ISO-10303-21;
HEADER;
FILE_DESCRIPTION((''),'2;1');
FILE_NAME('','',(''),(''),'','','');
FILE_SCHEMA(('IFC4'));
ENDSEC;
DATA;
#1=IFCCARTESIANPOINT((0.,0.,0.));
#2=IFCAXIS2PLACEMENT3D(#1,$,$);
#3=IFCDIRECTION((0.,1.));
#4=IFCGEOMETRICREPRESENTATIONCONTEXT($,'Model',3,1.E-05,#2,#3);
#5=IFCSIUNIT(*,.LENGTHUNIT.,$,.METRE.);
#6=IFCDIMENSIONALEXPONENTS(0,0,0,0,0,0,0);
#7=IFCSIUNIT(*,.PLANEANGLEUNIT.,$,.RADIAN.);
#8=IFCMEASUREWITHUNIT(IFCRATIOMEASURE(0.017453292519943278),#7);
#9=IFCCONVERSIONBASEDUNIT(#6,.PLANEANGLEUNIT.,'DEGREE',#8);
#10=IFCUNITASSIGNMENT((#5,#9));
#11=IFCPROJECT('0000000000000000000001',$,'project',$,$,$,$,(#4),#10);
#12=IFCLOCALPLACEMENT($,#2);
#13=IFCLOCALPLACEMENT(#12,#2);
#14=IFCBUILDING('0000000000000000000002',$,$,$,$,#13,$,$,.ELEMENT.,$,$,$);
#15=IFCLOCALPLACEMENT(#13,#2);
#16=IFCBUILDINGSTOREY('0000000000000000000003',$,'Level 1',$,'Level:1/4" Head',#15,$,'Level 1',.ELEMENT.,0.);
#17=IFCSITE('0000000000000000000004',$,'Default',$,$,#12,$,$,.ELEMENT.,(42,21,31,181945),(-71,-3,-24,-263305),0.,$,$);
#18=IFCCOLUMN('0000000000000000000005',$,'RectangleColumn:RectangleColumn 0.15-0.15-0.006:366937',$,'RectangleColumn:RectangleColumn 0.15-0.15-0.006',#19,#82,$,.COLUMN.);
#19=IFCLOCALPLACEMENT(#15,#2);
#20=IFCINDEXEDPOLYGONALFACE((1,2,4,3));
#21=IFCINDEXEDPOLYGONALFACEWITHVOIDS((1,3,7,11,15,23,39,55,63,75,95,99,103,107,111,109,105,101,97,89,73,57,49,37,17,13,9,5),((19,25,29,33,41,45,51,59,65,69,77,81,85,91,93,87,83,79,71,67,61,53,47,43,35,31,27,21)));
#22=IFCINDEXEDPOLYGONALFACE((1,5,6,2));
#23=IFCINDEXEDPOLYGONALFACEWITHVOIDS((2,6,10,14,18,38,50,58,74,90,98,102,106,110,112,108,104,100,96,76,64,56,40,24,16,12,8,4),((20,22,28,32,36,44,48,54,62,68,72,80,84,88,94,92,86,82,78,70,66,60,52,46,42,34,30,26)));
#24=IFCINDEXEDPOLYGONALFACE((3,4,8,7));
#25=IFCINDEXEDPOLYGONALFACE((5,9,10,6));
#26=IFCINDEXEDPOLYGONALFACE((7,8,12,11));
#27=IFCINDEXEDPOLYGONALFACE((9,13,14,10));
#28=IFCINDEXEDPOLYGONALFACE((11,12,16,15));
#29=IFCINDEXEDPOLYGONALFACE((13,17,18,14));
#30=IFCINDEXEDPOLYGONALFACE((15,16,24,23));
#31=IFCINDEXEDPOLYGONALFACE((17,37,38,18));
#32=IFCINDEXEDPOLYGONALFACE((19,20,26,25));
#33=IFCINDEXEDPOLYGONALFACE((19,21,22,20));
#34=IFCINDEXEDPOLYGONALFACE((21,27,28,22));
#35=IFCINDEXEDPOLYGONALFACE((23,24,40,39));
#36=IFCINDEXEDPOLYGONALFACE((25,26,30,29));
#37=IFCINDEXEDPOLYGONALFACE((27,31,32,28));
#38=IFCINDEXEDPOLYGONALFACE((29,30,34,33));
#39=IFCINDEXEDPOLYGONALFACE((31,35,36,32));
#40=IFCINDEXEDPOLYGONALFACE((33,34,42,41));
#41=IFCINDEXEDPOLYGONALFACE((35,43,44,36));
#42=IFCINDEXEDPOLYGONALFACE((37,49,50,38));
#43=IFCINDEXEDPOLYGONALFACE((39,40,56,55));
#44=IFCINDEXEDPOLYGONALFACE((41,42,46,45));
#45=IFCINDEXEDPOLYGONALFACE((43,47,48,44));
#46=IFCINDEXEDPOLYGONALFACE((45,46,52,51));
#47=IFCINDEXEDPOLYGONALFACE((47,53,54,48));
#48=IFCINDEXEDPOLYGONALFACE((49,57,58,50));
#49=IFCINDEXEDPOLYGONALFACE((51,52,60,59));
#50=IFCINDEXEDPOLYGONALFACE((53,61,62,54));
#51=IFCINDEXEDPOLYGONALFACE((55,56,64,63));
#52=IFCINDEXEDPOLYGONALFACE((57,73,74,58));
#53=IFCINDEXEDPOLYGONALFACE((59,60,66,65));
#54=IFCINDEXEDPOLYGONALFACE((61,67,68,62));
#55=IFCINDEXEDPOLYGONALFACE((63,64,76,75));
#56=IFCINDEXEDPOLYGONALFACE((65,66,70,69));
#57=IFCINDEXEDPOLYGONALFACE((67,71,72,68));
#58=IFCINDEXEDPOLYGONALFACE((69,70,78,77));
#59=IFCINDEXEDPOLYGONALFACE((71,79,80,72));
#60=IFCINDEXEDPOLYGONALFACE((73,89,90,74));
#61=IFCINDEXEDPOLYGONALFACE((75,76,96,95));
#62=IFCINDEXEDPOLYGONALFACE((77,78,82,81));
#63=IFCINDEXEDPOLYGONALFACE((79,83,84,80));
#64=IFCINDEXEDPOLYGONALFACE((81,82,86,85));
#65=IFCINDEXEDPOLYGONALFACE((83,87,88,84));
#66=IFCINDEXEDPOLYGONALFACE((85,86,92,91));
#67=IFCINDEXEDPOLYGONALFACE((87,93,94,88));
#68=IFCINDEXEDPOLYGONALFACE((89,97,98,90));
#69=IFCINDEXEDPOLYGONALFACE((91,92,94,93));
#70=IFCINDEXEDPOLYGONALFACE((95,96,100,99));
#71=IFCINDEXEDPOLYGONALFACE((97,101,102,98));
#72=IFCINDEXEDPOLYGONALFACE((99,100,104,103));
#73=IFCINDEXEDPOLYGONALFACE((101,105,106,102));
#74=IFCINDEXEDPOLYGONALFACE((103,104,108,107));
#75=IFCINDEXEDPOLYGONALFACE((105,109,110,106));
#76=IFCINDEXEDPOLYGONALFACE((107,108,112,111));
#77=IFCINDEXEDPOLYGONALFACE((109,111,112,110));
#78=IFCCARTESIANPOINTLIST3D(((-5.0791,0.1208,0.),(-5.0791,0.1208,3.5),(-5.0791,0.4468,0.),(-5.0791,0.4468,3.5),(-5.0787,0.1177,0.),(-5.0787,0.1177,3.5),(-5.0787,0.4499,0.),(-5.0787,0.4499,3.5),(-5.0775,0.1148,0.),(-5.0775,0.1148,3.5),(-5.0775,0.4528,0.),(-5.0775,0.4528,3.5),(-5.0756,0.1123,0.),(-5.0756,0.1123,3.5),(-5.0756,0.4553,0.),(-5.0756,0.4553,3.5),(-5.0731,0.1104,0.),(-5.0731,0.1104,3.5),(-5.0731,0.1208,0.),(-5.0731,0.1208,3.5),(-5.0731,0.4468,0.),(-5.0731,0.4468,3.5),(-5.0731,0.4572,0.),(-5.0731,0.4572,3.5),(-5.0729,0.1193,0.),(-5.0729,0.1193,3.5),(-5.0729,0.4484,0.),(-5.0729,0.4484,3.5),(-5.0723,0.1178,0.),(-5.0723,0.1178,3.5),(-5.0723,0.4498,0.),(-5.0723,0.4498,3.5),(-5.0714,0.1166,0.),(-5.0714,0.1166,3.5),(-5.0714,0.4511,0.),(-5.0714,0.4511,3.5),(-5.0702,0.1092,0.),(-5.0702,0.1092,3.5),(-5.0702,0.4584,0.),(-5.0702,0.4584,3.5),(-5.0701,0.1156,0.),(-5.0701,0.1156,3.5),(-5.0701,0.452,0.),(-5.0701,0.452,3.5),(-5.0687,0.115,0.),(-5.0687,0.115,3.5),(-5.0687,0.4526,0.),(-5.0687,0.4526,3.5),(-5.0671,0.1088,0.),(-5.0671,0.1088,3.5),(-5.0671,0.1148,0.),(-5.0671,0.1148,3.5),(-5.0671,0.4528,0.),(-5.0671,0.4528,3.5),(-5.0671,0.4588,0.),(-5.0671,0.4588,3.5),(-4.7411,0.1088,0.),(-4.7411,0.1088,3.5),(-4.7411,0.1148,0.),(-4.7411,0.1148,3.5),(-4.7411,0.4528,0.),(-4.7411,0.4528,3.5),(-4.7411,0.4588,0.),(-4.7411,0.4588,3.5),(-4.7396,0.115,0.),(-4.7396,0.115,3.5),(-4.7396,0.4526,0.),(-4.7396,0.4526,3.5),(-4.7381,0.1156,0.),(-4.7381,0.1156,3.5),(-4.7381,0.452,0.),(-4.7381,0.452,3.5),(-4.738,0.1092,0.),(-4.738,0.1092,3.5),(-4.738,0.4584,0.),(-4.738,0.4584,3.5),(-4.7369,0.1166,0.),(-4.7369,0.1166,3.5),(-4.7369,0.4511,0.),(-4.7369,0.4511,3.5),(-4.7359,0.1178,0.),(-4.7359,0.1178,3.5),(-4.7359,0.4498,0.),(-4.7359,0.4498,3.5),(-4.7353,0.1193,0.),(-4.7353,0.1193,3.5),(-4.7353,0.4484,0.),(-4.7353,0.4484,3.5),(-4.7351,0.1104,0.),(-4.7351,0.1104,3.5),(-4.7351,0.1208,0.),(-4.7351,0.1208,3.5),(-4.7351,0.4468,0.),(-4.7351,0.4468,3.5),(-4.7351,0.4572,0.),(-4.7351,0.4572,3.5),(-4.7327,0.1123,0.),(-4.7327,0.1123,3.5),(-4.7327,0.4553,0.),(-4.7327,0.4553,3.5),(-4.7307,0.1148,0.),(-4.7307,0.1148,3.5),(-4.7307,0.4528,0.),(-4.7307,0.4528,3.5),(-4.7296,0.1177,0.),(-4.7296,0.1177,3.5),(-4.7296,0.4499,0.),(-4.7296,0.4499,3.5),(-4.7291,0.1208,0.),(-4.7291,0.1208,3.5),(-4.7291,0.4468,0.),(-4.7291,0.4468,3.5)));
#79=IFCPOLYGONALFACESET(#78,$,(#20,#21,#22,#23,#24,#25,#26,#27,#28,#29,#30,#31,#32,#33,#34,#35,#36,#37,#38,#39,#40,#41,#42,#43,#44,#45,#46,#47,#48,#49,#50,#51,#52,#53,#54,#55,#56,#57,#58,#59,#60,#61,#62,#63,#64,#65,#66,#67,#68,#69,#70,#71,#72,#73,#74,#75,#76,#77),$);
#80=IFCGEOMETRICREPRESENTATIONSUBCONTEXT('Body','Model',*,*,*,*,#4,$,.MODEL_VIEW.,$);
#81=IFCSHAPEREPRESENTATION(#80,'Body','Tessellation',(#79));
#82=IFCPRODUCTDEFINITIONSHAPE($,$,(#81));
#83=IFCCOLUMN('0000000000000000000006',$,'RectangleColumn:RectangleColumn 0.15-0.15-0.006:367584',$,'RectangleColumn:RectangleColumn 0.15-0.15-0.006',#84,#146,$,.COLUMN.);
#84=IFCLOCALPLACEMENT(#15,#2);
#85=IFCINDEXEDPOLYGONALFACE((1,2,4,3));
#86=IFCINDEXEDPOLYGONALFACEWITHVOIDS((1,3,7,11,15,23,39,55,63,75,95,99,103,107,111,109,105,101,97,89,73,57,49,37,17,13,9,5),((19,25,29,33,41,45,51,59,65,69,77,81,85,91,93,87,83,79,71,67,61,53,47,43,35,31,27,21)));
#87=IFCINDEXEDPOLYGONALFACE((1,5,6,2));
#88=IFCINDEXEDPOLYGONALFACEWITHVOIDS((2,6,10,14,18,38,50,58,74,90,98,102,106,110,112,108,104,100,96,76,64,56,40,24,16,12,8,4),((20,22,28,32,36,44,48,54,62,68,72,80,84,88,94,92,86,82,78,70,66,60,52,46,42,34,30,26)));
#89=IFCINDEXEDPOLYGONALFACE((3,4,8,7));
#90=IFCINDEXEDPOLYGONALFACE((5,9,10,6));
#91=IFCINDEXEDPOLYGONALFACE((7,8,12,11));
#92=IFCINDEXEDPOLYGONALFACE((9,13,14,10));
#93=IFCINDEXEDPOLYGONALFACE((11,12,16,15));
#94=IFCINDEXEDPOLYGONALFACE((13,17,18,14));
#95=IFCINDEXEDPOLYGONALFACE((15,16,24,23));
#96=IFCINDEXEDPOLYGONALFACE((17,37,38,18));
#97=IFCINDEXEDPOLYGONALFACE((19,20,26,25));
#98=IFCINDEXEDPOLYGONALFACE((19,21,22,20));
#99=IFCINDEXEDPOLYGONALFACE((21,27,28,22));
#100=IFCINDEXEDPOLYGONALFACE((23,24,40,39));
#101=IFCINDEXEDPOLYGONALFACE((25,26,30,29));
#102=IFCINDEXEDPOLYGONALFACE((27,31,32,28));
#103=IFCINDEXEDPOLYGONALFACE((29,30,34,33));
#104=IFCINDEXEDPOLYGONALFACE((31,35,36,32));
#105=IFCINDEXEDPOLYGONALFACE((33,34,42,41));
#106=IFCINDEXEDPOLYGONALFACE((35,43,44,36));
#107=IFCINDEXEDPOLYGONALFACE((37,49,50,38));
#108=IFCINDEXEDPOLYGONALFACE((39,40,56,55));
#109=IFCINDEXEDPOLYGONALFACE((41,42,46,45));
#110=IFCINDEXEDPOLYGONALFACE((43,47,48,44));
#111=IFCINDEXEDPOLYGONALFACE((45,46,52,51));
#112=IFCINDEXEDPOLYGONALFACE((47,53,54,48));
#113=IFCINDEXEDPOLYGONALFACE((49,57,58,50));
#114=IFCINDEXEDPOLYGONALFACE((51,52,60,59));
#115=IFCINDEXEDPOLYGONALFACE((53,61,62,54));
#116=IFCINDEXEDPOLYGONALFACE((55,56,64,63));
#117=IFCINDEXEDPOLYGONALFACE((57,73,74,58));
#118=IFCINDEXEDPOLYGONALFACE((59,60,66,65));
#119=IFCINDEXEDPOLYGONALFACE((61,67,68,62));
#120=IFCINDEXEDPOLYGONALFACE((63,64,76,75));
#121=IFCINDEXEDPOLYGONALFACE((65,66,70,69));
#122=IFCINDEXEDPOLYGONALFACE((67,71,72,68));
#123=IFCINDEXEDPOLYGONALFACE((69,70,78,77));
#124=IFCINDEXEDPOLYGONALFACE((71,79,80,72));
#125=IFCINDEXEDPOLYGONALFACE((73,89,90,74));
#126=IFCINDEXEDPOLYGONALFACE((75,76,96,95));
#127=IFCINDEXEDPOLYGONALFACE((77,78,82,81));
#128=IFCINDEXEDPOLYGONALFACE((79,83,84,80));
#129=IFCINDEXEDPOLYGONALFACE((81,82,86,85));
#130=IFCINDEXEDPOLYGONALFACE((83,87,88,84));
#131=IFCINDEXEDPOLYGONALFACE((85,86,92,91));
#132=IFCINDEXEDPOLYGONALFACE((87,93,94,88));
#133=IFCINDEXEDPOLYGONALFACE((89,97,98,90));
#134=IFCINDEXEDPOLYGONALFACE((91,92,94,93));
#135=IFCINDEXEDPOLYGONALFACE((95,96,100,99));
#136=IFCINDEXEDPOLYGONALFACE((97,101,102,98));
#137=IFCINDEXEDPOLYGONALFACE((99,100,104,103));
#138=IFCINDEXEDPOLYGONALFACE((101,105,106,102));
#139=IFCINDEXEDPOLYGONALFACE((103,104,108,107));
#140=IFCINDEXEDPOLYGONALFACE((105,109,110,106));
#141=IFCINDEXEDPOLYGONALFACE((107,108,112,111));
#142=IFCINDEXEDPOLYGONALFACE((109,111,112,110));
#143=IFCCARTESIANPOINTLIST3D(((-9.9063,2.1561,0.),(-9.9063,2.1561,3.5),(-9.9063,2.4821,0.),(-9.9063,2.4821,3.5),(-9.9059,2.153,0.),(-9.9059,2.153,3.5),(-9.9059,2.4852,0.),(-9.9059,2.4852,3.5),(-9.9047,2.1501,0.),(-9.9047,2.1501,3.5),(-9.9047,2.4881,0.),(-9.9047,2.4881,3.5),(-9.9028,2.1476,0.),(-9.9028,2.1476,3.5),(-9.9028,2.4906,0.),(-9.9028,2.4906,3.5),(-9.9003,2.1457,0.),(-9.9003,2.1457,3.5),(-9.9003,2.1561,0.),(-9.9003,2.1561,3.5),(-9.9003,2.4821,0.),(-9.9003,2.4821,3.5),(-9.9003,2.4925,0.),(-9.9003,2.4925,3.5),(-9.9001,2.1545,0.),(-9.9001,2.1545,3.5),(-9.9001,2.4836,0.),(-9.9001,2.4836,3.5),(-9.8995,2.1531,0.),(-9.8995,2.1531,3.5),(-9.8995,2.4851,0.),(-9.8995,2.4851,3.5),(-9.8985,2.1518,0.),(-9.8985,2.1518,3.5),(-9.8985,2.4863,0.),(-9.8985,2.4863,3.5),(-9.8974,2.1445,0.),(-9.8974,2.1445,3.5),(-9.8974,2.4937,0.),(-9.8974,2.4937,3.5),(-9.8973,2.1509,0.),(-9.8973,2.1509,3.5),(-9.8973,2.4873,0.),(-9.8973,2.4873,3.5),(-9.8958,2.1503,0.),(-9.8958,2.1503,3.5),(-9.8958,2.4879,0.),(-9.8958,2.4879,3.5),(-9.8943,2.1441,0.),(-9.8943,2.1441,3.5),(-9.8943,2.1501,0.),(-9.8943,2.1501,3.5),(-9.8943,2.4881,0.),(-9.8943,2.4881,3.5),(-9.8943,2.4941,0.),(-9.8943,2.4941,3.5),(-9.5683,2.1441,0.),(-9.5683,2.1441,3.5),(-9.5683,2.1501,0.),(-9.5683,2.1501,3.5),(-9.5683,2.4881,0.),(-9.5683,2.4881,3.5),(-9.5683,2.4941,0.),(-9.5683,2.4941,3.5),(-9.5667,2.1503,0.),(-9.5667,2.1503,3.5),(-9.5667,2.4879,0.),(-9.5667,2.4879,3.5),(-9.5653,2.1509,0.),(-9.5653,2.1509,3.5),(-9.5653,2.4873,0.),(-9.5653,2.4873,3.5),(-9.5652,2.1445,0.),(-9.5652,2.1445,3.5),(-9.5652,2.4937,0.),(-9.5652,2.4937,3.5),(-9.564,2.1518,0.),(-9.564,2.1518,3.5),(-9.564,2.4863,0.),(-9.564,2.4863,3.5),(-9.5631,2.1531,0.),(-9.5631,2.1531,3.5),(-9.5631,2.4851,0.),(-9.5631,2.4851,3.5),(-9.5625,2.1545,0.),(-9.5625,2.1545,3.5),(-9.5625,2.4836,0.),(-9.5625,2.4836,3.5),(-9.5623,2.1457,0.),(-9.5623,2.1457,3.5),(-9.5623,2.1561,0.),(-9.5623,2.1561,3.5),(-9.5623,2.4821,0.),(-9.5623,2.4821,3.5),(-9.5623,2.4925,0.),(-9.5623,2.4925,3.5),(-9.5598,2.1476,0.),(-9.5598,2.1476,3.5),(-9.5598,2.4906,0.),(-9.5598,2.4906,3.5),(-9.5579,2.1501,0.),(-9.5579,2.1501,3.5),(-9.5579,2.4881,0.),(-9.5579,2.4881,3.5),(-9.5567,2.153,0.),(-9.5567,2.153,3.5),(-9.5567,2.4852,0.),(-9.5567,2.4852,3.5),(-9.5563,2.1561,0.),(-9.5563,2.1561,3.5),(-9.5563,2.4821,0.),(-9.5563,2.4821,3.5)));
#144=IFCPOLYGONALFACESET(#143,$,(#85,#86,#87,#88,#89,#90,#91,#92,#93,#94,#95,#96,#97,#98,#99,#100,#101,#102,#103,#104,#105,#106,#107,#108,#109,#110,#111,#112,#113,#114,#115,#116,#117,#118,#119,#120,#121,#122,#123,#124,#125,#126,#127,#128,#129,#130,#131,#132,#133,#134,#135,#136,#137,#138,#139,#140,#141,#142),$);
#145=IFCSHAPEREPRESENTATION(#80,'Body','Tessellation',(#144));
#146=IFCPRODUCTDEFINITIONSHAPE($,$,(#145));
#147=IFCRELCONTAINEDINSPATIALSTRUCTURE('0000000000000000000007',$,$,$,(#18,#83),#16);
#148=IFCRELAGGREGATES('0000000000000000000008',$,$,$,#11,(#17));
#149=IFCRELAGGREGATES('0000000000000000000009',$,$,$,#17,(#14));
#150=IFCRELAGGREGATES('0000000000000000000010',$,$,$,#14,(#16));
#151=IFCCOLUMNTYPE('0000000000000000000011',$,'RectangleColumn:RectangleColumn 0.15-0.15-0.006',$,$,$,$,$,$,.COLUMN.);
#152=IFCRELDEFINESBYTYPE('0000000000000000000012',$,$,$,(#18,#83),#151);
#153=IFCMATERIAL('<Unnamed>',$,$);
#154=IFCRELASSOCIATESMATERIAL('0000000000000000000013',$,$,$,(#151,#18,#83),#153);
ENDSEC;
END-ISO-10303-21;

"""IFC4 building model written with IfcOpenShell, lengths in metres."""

from ifc_helpers import new_model, entity, si_unit, converted_unit, direction, frame, origin, place, context, subcontext, project, spatial, line, arc, indexed_curve, outline, extrude, source, transform, mapped, material, type_object, type_shapes, element, save


model = new_model("IFC4")

# Units and contexts
model_context = context("Model", 3, precision=1e-05, world=origin(), true_north=direction((0.0, 1.0)))
body_context = subcontext(model_context, "Body", "Model", "MODEL_VIEW")
ifc_project = project(units=[si_unit("LENGTHUNIT", "METRE"), converted_unit("PLANEANGLEUNIT", "DEGREE", entity("IfcRatioMeasure", 0.017453292519943278), si_unit("PLANEANGLEUNIT", "RADIAN"), dimensions=[0, 0, 0, 0, 0, 0, 0])], contexts=[model_context])

# Site, building, storey
site_placement = place(None, origin())
site = spatial("IfcSite", under=ifc_project, at=site_placement, Name="Default", CompositionType="ELEMENT", RefLatitude=(42, 21, 31, 181945), RefLongitude=(-71, -3, -24, -263305), RefElevation=0.0)
building_placement = place(site_placement, origin())
building = spatial("IfcBuilding", under=site, at=building_placement, CompositionType="ELEMENT")
storey_placement = place(building_placement, origin())
storey = spatial("IfcBuildingStorey", under=building, at=storey_placement, Name="Level 1", ObjectType="Level:1/4\" Head", LongName="Level 1", CompositionType="ELEMENT", Elevation=0.0)

# Columns
ifc_material_1 = material(Name="<Unnamed>")
column_type = type_object("IfcColumnType", Name="RectangleColumn:RectangleColumn 0.15-0.15-0.006", PredefinedType="COLUMN", material=ifc_material_1)
shared_shape = source(origin(), body_context, "Body", "SweptSolid", [
    extrude(outline(indexed_curve([(-0.163, -0.175), (0.163, -0.175), (0.1715, -0.1715), (0.175, -0.163), (0.175, 0.163), (0.1715, 0.1715), (0.163, 0.175), (-0.163, 0.175), (-0.1715, 0.1715), (-0.175, 0.163), (-0.175, -0.163), (-0.1715, -0.1715)], segments=[line(1, 2), arc(2, 3, 4), line(4, 5), arc(5, 6, 7), line(7, 8), arc(8, 9, 10), line(10, 11), arc(11, 12, 1)], self_intersect=False), holes=[indexed_curve([(-0.163, -0.169), (-0.1672, -0.1672), (-0.169, -0.163), (-0.169, 0.163), (-0.1672, 0.1672), (-0.163, 0.169), (0.163, 0.169), (0.1672, 0.1672), (0.169, 0.163), (0.169, -0.163), (0.1672, -0.1672), (0.163, -0.169)], segments=[arc(1, 2, 3), line(3, 4), arc(4, 5, 6), line(6, 7), arc(7, 8, 9), line(9, 10), arc(10, 11, 12), line(12, 1)], self_intersect=False)]), frame((0.0, 0.0, 0.0), z_axis=(0.0, 0.0, 1.0), x_axis=(-1.0, 0.0, 0.0)), (0.0, 0.0, 1.0), 3.5),
])
type_shapes(column_type, [shared_shape])
for number, where, name in (
    (1, (-4.9041, 0.2838, 0.0), "RectangleColumn:RectangleColumn 0.15-0.15-0.006:366937"),
    (2, (-9.7313, 2.3191, 0.0), "RectangleColumn:RectangleColumn 0.15-0.15-0.006:367584"),
):
    element("IfcColumn", number, at=place(storey_placement, frame(where)), inside=storey, type_object=column_type, material=ifc_material_1, Name=name, ObjectType="RectangleColumn:RectangleColumn 0.15-0.15-0.006", PredefinedType="COLUMN", context=body_context, shape_type="MappedRepresentation", body=[
        mapped(shared_shape, transform((0.0, 0.0, 0.0), scale=1.0)),
    ])

save(model, "model.ifc")
